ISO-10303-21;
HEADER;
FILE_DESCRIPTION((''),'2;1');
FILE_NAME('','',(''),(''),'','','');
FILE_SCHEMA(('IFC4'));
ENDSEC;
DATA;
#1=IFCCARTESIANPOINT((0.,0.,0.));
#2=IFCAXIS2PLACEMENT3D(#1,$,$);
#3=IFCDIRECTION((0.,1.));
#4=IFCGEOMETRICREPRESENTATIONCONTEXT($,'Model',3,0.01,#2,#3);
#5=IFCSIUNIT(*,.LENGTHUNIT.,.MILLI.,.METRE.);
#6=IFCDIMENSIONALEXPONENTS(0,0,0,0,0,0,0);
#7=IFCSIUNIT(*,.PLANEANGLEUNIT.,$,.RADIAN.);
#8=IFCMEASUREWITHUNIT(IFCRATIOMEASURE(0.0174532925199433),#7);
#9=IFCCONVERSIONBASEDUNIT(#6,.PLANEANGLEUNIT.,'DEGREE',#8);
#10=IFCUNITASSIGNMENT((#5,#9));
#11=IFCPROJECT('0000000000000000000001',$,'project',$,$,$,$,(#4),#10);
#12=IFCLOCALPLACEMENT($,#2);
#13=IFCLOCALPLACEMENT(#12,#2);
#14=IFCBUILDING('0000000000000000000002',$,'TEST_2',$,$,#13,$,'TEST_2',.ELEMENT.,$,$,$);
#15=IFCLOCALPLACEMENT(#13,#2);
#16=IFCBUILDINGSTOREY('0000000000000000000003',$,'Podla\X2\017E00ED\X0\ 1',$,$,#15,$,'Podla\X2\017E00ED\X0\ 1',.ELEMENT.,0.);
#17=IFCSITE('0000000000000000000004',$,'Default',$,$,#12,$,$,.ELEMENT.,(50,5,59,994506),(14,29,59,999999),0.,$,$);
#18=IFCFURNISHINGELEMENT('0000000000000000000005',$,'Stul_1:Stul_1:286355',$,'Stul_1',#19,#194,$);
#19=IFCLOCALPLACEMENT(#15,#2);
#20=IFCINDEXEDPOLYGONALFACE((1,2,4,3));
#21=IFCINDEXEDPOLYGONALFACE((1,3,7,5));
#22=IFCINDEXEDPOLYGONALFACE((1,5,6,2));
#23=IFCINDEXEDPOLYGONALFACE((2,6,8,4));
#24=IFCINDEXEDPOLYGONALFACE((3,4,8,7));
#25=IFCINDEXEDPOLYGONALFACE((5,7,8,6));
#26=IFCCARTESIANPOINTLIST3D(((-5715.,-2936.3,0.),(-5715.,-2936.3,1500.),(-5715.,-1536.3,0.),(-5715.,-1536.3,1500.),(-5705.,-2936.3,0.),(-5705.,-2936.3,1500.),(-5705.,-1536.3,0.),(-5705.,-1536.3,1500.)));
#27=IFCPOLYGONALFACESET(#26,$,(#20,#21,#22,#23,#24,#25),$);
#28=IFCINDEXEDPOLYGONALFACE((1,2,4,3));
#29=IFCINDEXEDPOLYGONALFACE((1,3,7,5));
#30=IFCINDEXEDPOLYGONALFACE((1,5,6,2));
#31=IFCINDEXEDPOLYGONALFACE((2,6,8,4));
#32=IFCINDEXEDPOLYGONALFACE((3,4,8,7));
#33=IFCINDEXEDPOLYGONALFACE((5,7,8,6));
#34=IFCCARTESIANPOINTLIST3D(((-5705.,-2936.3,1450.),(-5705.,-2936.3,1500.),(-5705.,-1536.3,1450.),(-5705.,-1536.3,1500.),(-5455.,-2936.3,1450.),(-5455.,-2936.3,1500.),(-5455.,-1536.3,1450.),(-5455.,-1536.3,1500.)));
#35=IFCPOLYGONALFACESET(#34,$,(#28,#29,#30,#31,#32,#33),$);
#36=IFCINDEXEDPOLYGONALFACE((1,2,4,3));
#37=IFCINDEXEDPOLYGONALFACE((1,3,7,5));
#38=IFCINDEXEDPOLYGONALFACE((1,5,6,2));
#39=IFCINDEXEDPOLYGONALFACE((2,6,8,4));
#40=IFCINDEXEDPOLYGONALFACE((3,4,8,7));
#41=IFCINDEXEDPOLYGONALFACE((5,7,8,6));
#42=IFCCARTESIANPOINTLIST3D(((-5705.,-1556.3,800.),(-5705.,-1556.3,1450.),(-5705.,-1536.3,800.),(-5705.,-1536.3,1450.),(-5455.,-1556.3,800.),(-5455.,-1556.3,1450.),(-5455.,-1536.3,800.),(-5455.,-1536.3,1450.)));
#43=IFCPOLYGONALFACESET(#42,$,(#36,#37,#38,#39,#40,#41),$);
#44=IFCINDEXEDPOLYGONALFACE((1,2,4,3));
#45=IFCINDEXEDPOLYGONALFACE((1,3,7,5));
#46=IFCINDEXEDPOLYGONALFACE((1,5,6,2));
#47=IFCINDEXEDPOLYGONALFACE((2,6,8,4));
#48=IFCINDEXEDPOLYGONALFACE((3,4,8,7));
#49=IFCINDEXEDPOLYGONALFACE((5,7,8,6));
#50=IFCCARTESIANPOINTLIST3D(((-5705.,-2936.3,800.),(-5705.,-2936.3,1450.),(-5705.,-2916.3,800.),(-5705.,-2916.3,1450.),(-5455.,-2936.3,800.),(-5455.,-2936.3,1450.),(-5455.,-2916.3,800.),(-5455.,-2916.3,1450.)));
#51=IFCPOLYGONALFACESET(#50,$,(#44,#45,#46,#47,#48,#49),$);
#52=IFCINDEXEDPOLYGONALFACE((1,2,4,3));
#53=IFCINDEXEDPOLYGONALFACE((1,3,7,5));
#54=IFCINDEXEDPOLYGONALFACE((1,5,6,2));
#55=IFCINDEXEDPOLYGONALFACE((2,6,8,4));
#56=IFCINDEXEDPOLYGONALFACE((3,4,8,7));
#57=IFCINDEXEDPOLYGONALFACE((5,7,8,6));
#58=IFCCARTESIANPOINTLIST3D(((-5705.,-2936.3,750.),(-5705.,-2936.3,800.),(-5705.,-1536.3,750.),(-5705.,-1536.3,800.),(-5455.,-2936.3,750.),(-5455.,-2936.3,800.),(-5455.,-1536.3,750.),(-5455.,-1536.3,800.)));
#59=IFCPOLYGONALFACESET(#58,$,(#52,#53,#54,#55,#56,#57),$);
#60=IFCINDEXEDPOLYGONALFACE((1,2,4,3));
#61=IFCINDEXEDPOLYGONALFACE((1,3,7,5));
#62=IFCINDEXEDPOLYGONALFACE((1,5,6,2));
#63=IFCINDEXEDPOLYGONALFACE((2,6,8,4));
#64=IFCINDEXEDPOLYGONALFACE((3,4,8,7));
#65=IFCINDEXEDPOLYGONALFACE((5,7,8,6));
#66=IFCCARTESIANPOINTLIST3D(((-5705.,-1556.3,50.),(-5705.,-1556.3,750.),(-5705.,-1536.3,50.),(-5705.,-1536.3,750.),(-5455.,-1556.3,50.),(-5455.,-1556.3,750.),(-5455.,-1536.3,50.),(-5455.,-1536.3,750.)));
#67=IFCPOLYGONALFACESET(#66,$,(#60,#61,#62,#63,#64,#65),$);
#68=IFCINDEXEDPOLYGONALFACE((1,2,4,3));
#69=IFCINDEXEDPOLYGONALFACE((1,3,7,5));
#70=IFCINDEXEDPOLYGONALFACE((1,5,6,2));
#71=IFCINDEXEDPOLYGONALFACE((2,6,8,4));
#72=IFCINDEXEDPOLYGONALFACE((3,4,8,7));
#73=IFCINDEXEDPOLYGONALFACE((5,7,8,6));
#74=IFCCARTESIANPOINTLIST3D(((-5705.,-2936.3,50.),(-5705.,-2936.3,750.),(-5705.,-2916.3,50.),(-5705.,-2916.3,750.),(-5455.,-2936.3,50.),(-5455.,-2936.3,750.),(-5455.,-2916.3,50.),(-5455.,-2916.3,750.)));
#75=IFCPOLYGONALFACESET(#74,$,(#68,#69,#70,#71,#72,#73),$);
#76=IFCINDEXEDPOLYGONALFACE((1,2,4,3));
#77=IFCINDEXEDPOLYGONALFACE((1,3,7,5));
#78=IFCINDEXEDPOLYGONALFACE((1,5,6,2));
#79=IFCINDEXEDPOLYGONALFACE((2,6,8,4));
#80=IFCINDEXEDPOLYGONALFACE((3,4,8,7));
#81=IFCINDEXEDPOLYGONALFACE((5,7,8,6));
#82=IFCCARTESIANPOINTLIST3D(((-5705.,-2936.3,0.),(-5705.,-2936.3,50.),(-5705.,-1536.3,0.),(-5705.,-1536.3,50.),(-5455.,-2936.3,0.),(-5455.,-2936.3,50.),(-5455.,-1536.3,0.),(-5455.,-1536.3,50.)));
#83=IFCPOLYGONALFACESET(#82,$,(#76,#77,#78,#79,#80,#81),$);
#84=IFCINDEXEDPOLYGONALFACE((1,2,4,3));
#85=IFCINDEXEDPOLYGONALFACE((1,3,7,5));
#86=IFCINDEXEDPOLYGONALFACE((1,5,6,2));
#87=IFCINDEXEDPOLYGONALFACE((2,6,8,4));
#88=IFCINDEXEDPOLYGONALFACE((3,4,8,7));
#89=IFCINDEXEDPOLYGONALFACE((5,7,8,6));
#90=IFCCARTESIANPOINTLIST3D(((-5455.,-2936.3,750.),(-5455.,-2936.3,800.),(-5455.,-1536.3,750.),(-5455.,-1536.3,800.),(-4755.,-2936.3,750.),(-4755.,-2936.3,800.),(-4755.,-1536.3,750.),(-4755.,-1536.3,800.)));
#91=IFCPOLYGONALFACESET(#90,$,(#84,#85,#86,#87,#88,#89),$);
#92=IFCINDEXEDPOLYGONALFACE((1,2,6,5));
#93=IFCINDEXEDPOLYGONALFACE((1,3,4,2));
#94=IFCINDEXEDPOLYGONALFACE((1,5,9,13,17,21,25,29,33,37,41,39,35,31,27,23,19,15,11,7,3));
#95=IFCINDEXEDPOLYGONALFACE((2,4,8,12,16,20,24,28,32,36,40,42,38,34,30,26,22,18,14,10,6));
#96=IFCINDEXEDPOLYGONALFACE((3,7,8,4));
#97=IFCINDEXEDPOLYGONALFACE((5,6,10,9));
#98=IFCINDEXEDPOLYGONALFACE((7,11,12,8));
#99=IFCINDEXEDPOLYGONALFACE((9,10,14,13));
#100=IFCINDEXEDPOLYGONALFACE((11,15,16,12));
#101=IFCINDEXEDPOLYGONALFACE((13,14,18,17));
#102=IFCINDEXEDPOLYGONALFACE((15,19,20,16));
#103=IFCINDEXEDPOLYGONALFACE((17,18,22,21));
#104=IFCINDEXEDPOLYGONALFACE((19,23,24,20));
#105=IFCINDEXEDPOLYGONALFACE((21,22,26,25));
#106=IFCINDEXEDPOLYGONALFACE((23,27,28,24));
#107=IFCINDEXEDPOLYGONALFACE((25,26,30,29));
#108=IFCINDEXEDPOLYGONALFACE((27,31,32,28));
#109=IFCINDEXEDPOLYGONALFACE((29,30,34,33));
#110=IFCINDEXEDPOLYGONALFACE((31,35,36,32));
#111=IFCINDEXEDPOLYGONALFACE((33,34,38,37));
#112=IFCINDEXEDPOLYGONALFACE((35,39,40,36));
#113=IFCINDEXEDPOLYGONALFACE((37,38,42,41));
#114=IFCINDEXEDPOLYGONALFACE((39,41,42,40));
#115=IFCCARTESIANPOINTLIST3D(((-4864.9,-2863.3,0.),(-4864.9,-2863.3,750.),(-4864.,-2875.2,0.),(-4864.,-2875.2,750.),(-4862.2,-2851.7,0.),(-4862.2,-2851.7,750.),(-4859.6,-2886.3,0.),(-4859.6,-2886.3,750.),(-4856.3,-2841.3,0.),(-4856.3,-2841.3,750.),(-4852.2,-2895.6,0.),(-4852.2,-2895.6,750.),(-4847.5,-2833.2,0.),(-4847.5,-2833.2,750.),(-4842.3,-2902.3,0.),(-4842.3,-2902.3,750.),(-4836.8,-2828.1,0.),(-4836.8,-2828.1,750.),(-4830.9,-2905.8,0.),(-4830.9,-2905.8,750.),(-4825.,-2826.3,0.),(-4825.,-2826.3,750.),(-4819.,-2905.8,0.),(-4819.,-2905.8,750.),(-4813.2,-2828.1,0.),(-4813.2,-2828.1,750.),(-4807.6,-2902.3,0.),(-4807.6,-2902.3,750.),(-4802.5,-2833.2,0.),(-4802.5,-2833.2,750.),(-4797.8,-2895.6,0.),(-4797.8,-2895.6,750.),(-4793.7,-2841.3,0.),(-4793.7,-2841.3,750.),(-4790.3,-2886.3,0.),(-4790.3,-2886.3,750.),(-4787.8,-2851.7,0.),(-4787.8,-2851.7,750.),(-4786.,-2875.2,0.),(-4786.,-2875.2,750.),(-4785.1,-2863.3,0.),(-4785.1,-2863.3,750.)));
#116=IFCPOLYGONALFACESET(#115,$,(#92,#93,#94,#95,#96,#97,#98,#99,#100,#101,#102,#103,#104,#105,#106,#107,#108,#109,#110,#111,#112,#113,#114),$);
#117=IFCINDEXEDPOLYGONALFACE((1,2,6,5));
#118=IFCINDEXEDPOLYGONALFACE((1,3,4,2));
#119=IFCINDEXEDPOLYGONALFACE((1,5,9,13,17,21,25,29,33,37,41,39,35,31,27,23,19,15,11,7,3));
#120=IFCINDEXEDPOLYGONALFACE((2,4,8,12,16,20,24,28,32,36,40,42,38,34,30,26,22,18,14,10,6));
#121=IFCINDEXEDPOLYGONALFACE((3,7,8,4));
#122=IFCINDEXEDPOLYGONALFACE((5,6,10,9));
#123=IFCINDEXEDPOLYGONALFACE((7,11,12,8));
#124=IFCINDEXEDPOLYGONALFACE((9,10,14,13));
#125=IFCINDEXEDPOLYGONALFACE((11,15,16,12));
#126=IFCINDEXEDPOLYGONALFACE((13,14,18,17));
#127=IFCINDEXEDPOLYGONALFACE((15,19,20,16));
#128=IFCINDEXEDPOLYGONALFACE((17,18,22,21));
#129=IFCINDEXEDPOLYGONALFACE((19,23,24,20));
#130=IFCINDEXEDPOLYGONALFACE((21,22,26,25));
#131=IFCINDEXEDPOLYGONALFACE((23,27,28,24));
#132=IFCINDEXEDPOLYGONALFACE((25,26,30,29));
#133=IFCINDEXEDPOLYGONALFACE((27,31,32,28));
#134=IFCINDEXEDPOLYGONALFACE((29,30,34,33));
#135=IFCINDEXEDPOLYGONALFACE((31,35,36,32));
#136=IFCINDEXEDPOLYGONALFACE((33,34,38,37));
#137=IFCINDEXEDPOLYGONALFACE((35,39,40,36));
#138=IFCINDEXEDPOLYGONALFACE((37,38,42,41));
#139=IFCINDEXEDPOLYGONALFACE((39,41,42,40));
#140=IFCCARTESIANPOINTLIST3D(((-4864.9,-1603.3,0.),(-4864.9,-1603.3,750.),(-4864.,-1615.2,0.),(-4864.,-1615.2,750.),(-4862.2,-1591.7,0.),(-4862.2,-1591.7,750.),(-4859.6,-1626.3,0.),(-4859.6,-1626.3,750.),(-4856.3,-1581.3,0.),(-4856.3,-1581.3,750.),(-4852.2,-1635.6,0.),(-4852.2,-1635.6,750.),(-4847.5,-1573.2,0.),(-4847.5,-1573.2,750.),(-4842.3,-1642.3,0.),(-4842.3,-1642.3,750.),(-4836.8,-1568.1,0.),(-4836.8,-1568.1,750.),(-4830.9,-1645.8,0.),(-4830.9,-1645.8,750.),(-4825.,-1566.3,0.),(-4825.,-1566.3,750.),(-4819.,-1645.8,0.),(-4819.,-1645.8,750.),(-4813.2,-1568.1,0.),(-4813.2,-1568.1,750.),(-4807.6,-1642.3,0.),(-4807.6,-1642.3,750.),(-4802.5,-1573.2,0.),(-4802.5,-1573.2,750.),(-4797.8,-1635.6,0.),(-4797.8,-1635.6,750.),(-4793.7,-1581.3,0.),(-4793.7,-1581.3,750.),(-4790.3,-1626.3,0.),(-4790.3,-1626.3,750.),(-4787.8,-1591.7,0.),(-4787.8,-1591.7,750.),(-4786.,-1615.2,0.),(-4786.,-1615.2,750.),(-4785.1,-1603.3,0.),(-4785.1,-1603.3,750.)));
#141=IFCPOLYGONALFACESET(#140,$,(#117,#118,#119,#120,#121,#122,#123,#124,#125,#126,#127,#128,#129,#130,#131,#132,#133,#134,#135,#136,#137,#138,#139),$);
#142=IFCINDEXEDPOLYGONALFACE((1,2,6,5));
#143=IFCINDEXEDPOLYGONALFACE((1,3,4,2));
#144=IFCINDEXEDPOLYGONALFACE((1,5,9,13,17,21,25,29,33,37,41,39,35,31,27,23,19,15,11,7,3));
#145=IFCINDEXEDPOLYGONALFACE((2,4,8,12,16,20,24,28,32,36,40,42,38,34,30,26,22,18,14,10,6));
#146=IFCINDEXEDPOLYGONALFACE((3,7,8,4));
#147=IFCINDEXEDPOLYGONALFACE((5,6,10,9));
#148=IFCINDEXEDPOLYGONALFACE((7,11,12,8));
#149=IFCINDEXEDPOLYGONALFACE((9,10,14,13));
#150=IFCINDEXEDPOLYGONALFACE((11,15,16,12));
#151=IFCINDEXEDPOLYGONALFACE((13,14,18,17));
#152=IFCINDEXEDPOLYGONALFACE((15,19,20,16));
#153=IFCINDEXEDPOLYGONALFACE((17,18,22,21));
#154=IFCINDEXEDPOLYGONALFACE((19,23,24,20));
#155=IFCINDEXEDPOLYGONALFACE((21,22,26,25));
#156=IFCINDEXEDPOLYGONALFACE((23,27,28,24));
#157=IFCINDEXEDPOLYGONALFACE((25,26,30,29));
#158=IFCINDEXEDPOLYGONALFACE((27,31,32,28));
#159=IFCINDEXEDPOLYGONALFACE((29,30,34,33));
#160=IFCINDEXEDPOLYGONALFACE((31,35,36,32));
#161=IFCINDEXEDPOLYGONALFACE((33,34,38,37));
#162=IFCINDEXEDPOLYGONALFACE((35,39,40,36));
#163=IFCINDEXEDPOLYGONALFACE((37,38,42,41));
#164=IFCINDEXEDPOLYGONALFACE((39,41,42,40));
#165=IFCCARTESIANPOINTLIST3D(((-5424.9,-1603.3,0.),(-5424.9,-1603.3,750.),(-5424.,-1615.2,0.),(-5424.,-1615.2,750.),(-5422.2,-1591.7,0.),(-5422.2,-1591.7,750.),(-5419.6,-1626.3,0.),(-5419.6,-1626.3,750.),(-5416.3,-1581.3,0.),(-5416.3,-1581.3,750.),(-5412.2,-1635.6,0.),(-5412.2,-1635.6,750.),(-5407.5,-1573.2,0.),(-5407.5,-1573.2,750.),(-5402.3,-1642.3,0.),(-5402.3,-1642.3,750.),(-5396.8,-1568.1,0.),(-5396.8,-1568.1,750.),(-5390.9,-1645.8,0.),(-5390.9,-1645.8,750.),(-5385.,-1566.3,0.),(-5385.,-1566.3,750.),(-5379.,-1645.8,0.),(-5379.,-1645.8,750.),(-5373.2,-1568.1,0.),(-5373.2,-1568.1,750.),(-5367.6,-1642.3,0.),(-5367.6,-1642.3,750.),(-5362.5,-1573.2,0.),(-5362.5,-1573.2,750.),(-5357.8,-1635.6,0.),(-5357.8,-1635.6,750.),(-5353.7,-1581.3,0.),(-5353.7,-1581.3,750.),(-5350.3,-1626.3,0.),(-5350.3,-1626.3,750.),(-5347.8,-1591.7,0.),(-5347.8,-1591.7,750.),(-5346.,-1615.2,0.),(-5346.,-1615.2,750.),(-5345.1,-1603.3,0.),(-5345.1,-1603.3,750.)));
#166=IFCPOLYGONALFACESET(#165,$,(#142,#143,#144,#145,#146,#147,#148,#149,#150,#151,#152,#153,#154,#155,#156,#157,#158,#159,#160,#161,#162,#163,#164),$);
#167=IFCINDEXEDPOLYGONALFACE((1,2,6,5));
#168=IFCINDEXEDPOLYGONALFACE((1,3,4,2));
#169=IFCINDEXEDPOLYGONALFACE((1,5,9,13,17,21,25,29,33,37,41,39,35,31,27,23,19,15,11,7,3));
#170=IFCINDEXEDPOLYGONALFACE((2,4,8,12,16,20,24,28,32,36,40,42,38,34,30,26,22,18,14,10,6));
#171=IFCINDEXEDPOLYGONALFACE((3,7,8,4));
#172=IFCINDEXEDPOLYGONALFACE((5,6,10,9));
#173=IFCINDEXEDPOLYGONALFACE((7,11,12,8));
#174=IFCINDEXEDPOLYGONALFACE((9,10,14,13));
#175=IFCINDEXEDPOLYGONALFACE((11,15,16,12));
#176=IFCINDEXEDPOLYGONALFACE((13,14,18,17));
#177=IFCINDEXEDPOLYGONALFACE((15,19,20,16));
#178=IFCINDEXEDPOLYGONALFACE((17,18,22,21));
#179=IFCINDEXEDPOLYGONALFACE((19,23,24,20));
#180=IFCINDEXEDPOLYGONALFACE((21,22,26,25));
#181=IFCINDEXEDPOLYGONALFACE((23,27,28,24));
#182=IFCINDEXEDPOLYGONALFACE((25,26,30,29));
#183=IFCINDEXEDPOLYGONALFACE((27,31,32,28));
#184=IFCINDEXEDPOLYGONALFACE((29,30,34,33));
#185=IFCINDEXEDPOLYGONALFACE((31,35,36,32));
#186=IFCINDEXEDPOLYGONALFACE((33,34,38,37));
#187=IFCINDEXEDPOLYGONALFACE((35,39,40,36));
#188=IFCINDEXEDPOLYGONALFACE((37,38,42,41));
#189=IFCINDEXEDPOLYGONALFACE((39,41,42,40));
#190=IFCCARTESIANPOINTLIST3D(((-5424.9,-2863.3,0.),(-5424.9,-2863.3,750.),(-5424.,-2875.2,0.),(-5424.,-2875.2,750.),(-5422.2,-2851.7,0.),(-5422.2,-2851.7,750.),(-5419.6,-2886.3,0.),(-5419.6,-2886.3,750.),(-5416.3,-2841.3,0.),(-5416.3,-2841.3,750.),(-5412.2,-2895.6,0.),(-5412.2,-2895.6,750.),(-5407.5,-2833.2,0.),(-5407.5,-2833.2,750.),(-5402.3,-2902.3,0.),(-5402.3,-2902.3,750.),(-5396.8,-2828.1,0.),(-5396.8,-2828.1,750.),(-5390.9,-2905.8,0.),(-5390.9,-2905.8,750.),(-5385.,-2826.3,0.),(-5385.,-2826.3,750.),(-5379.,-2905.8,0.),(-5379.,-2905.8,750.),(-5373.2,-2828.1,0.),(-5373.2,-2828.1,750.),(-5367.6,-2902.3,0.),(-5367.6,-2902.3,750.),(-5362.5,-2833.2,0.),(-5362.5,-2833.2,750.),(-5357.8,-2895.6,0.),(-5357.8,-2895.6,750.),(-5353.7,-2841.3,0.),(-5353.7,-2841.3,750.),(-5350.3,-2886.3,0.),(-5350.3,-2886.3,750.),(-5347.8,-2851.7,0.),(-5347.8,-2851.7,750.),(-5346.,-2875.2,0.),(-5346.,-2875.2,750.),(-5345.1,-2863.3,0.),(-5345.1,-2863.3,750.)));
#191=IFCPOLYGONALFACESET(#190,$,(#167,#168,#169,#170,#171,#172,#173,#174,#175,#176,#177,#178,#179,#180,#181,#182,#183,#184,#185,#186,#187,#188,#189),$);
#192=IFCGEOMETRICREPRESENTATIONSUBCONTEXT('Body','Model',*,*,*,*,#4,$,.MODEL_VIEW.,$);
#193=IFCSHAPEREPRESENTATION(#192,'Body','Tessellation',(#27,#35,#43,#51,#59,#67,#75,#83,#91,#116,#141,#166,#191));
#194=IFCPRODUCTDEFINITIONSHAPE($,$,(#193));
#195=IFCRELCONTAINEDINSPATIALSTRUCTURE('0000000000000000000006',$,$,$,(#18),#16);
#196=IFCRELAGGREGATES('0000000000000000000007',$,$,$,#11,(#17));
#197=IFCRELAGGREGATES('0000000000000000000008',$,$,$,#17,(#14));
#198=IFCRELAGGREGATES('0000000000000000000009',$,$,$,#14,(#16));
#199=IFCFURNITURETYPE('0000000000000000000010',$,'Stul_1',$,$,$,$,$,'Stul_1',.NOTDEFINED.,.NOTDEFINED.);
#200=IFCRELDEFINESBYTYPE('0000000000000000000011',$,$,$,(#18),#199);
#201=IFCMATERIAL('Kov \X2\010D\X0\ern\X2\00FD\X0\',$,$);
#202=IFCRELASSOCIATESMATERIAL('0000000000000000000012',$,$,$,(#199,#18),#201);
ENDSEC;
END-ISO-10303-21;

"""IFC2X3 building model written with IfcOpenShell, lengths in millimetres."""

from ifc_helpers import new_model, entity, si_unit, converted_unit, direction, frame, frame_2d, origin, origin_2d_with_axis, place, context, subcontext, project, spatial, rectangle, circle, extrude, source, transform, mapped, material, type_object, type_shapes, element, save


model = new_model("IFC2X3")

# Units and contexts
model_context = context("Model", 3, precision=0.01, world=origin(), true_north=direction((0.0, 1.0)))
body_context = subcontext(model_context, "Body", "Model", "MODEL_VIEW")
ifc_project = project(units=[si_unit("LENGTHUNIT", "METRE", prefix="MILLI"), converted_unit("PLANEANGLEUNIT", "DEGREE", entity("IfcRatioMeasure", 0.0174532925199433), si_unit("PLANEANGLEUNIT", "RADIAN"), dimensions=[0, 0, 0, 0, 0, 0, 0])], contexts=[model_context])

# Site, building, storey
site_placement = place(None, origin())
site = spatial("IfcSite", under=ifc_project, at=site_placement, Name="Default", CompositionType="ELEMENT", RefLatitude=(50, 5, 59, 994506), RefLongitude=(14, 29, 59, 999999), RefElevation=0.0)
building_placement = place(site_placement, origin())
building = spatial("IfcBuilding", under=site, at=building_placement, Name="TEST_2", LongName="TEST_2", CompositionType="ELEMENT")
storey_placement = place(building_placement, origin())
storey = spatial("IfcBuildingStorey", under=building, at=storey_placement, Name="Podlaží 1", LongName="Podlaží 1", CompositionType="ELEMENT", Elevation=0.0)

# Furnishing element
ifc_material_1 = material(Name="Kov černý")
furniture_type = type_object("IfcFurnitureType", Name="Stul_1", ElementType="Stul_1", material=ifc_material_1)
shared_shape_1 = source(origin(), body_context, "Body", "SweptSolid", [
    extrude(rectangle(XDim=1400.0, YDim=10.0, at=origin_2d_with_axis()), frame((0.0, 605.0, 0.0), z_axis=(0.0, 0.0, 1.0), x_axis=(-1.0, 0.0, 0.0)), (0.0, 0.0, 1.0), 1500.0),
    extrude(rectangle(XDim=1400.0, YDim=250.0, at=frame_2d((0.0, 0.0), x_axis=(1.0, 0.0))), frame((0.0, 475.0, 1450.0), z_axis=(0.0, 0.0, 1.0), x_axis=(-1.0, 0.0, 0.0)), (0.0, 0.0, 1.0), 50.0),
    extrude(rectangle(XDim=20.0, YDim=250.0, at=origin_2d_with_axis()), frame((690.0, 475.0, 800.0), z_axis=(0.0, 0.0, 1.0), x_axis=(-1.0, 0.0, 0.0)), (0.0, 0.0, 1.0), 650.0),
    extrude(rectangle(XDim=20.0, YDim=250.0, at=frame_2d((0.0, 0.0), x_axis=(1.0, 0.0))), frame((-690.0, 475.0, 800.0), z_axis=(0.0, 0.0, 1.0), x_axis=(-1.0, 0.0, 0.0)), (0.0, 0.0, 1.0), 650.0),
    extrude(rectangle(XDim=1400.0, YDim=250.0, at=origin_2d_with_axis()), frame((0.0, 475.0, 750.0), z_axis=(0.0, 0.0, 1.0), x_axis=(-1.0, 0.0, 0.0)), (0.0, 0.0, 1.0), 50.0),
    extrude(rectangle(XDim=20.0, YDim=250.0, at=origin_2d_with_axis()), frame((690.0, 475.0, 50.0), z_axis=(0.0, 0.0, 1.0), x_axis=(-1.0, 0.0, 0.0)), (0.0, 0.0, 1.0), 700.0),
    extrude(rectangle(XDim=20.0, YDim=250.0, at=frame_2d((0.0, 0.0), x_axis=(1.0, 0.0))), frame((-690.0, 475.0, 50.0), z_axis=(0.0, 0.0, 1.0), x_axis=(-1.0, 0.0, 0.0)), (0.0, 0.0, 1.0), 700.0),
    extrude(rectangle(XDim=1400.0, YDim=250.0, at=origin_2d_with_axis()), frame((0.0, 475.0, 0.0), z_axis=(0.0, 0.0, 1.0), x_axis=(-1.0, 0.0, 0.0)), (0.0, 0.0, 1.0), 50.0),
    extrude(rectangle(XDim=1400.0, YDim=700.0, at=origin_2d_with_axis()), frame((0.0, 0.0, 750.0), z_axis=(0.0, 0.0, 1.0), x_axis=(-1.0, 0.0, 0.0)), (0.0, 0.0, 1.0), 50.0),
    extrude(circle(Radius=40.0, at=frame_2d((0.0, 0.0), x_axis=(1.0, 0.0))), frame((-630.0, -280.0, 0.0)), (0.0, 0.0, 1.0), 750.0),
    extrude(circle(Radius=40.0, at=frame_2d((0.0, 0.0), x_axis=(1.0, 0.0))), frame((630.0, -280.0, 0.0)), (0.0, 0.0, 1.0), 750.0),
    extrude(circle(Radius=40.0, at=frame_2d((0.0, 0.0), x_axis=(1.0, 0.0))), frame((630.0, 280.0, 0.0)), (0.0, 0.0, 1.0), 750.0),
    extrude(circle(Radius=40.0, at=frame_2d((0.0, 0.0), x_axis=(1.0, 0.0))), frame((-630.0, 280.0, 0.0)), (0.0, 0.0, 1.0), 750.0),
])
type_shapes(furniture_type, [shared_shape_1])
for number, where, z_axis, x_axis, name in (
    (1, (-5105.0, -2236.3, 0.0), (0.0, 0.0, 1.0), (0.0, 1.0, 0.0), "Stul_1:Stul_1:286355"),
):
    element("IfcFurnishingElement", number, at=place(storey_placement, frame(where, z_axis=z_axis, x_axis=x_axis)), inside=storey, type_object=furniture_type, material=ifc_material_1, Name=name, ObjectType="Stul_1", context=body_context, shape_type="MappedRepresentation", body=[
        mapped(shared_shape_1, transform((0.0, 0.0, 0.0), scale=1.0)),
    ])

save(model, "model.ifc")
